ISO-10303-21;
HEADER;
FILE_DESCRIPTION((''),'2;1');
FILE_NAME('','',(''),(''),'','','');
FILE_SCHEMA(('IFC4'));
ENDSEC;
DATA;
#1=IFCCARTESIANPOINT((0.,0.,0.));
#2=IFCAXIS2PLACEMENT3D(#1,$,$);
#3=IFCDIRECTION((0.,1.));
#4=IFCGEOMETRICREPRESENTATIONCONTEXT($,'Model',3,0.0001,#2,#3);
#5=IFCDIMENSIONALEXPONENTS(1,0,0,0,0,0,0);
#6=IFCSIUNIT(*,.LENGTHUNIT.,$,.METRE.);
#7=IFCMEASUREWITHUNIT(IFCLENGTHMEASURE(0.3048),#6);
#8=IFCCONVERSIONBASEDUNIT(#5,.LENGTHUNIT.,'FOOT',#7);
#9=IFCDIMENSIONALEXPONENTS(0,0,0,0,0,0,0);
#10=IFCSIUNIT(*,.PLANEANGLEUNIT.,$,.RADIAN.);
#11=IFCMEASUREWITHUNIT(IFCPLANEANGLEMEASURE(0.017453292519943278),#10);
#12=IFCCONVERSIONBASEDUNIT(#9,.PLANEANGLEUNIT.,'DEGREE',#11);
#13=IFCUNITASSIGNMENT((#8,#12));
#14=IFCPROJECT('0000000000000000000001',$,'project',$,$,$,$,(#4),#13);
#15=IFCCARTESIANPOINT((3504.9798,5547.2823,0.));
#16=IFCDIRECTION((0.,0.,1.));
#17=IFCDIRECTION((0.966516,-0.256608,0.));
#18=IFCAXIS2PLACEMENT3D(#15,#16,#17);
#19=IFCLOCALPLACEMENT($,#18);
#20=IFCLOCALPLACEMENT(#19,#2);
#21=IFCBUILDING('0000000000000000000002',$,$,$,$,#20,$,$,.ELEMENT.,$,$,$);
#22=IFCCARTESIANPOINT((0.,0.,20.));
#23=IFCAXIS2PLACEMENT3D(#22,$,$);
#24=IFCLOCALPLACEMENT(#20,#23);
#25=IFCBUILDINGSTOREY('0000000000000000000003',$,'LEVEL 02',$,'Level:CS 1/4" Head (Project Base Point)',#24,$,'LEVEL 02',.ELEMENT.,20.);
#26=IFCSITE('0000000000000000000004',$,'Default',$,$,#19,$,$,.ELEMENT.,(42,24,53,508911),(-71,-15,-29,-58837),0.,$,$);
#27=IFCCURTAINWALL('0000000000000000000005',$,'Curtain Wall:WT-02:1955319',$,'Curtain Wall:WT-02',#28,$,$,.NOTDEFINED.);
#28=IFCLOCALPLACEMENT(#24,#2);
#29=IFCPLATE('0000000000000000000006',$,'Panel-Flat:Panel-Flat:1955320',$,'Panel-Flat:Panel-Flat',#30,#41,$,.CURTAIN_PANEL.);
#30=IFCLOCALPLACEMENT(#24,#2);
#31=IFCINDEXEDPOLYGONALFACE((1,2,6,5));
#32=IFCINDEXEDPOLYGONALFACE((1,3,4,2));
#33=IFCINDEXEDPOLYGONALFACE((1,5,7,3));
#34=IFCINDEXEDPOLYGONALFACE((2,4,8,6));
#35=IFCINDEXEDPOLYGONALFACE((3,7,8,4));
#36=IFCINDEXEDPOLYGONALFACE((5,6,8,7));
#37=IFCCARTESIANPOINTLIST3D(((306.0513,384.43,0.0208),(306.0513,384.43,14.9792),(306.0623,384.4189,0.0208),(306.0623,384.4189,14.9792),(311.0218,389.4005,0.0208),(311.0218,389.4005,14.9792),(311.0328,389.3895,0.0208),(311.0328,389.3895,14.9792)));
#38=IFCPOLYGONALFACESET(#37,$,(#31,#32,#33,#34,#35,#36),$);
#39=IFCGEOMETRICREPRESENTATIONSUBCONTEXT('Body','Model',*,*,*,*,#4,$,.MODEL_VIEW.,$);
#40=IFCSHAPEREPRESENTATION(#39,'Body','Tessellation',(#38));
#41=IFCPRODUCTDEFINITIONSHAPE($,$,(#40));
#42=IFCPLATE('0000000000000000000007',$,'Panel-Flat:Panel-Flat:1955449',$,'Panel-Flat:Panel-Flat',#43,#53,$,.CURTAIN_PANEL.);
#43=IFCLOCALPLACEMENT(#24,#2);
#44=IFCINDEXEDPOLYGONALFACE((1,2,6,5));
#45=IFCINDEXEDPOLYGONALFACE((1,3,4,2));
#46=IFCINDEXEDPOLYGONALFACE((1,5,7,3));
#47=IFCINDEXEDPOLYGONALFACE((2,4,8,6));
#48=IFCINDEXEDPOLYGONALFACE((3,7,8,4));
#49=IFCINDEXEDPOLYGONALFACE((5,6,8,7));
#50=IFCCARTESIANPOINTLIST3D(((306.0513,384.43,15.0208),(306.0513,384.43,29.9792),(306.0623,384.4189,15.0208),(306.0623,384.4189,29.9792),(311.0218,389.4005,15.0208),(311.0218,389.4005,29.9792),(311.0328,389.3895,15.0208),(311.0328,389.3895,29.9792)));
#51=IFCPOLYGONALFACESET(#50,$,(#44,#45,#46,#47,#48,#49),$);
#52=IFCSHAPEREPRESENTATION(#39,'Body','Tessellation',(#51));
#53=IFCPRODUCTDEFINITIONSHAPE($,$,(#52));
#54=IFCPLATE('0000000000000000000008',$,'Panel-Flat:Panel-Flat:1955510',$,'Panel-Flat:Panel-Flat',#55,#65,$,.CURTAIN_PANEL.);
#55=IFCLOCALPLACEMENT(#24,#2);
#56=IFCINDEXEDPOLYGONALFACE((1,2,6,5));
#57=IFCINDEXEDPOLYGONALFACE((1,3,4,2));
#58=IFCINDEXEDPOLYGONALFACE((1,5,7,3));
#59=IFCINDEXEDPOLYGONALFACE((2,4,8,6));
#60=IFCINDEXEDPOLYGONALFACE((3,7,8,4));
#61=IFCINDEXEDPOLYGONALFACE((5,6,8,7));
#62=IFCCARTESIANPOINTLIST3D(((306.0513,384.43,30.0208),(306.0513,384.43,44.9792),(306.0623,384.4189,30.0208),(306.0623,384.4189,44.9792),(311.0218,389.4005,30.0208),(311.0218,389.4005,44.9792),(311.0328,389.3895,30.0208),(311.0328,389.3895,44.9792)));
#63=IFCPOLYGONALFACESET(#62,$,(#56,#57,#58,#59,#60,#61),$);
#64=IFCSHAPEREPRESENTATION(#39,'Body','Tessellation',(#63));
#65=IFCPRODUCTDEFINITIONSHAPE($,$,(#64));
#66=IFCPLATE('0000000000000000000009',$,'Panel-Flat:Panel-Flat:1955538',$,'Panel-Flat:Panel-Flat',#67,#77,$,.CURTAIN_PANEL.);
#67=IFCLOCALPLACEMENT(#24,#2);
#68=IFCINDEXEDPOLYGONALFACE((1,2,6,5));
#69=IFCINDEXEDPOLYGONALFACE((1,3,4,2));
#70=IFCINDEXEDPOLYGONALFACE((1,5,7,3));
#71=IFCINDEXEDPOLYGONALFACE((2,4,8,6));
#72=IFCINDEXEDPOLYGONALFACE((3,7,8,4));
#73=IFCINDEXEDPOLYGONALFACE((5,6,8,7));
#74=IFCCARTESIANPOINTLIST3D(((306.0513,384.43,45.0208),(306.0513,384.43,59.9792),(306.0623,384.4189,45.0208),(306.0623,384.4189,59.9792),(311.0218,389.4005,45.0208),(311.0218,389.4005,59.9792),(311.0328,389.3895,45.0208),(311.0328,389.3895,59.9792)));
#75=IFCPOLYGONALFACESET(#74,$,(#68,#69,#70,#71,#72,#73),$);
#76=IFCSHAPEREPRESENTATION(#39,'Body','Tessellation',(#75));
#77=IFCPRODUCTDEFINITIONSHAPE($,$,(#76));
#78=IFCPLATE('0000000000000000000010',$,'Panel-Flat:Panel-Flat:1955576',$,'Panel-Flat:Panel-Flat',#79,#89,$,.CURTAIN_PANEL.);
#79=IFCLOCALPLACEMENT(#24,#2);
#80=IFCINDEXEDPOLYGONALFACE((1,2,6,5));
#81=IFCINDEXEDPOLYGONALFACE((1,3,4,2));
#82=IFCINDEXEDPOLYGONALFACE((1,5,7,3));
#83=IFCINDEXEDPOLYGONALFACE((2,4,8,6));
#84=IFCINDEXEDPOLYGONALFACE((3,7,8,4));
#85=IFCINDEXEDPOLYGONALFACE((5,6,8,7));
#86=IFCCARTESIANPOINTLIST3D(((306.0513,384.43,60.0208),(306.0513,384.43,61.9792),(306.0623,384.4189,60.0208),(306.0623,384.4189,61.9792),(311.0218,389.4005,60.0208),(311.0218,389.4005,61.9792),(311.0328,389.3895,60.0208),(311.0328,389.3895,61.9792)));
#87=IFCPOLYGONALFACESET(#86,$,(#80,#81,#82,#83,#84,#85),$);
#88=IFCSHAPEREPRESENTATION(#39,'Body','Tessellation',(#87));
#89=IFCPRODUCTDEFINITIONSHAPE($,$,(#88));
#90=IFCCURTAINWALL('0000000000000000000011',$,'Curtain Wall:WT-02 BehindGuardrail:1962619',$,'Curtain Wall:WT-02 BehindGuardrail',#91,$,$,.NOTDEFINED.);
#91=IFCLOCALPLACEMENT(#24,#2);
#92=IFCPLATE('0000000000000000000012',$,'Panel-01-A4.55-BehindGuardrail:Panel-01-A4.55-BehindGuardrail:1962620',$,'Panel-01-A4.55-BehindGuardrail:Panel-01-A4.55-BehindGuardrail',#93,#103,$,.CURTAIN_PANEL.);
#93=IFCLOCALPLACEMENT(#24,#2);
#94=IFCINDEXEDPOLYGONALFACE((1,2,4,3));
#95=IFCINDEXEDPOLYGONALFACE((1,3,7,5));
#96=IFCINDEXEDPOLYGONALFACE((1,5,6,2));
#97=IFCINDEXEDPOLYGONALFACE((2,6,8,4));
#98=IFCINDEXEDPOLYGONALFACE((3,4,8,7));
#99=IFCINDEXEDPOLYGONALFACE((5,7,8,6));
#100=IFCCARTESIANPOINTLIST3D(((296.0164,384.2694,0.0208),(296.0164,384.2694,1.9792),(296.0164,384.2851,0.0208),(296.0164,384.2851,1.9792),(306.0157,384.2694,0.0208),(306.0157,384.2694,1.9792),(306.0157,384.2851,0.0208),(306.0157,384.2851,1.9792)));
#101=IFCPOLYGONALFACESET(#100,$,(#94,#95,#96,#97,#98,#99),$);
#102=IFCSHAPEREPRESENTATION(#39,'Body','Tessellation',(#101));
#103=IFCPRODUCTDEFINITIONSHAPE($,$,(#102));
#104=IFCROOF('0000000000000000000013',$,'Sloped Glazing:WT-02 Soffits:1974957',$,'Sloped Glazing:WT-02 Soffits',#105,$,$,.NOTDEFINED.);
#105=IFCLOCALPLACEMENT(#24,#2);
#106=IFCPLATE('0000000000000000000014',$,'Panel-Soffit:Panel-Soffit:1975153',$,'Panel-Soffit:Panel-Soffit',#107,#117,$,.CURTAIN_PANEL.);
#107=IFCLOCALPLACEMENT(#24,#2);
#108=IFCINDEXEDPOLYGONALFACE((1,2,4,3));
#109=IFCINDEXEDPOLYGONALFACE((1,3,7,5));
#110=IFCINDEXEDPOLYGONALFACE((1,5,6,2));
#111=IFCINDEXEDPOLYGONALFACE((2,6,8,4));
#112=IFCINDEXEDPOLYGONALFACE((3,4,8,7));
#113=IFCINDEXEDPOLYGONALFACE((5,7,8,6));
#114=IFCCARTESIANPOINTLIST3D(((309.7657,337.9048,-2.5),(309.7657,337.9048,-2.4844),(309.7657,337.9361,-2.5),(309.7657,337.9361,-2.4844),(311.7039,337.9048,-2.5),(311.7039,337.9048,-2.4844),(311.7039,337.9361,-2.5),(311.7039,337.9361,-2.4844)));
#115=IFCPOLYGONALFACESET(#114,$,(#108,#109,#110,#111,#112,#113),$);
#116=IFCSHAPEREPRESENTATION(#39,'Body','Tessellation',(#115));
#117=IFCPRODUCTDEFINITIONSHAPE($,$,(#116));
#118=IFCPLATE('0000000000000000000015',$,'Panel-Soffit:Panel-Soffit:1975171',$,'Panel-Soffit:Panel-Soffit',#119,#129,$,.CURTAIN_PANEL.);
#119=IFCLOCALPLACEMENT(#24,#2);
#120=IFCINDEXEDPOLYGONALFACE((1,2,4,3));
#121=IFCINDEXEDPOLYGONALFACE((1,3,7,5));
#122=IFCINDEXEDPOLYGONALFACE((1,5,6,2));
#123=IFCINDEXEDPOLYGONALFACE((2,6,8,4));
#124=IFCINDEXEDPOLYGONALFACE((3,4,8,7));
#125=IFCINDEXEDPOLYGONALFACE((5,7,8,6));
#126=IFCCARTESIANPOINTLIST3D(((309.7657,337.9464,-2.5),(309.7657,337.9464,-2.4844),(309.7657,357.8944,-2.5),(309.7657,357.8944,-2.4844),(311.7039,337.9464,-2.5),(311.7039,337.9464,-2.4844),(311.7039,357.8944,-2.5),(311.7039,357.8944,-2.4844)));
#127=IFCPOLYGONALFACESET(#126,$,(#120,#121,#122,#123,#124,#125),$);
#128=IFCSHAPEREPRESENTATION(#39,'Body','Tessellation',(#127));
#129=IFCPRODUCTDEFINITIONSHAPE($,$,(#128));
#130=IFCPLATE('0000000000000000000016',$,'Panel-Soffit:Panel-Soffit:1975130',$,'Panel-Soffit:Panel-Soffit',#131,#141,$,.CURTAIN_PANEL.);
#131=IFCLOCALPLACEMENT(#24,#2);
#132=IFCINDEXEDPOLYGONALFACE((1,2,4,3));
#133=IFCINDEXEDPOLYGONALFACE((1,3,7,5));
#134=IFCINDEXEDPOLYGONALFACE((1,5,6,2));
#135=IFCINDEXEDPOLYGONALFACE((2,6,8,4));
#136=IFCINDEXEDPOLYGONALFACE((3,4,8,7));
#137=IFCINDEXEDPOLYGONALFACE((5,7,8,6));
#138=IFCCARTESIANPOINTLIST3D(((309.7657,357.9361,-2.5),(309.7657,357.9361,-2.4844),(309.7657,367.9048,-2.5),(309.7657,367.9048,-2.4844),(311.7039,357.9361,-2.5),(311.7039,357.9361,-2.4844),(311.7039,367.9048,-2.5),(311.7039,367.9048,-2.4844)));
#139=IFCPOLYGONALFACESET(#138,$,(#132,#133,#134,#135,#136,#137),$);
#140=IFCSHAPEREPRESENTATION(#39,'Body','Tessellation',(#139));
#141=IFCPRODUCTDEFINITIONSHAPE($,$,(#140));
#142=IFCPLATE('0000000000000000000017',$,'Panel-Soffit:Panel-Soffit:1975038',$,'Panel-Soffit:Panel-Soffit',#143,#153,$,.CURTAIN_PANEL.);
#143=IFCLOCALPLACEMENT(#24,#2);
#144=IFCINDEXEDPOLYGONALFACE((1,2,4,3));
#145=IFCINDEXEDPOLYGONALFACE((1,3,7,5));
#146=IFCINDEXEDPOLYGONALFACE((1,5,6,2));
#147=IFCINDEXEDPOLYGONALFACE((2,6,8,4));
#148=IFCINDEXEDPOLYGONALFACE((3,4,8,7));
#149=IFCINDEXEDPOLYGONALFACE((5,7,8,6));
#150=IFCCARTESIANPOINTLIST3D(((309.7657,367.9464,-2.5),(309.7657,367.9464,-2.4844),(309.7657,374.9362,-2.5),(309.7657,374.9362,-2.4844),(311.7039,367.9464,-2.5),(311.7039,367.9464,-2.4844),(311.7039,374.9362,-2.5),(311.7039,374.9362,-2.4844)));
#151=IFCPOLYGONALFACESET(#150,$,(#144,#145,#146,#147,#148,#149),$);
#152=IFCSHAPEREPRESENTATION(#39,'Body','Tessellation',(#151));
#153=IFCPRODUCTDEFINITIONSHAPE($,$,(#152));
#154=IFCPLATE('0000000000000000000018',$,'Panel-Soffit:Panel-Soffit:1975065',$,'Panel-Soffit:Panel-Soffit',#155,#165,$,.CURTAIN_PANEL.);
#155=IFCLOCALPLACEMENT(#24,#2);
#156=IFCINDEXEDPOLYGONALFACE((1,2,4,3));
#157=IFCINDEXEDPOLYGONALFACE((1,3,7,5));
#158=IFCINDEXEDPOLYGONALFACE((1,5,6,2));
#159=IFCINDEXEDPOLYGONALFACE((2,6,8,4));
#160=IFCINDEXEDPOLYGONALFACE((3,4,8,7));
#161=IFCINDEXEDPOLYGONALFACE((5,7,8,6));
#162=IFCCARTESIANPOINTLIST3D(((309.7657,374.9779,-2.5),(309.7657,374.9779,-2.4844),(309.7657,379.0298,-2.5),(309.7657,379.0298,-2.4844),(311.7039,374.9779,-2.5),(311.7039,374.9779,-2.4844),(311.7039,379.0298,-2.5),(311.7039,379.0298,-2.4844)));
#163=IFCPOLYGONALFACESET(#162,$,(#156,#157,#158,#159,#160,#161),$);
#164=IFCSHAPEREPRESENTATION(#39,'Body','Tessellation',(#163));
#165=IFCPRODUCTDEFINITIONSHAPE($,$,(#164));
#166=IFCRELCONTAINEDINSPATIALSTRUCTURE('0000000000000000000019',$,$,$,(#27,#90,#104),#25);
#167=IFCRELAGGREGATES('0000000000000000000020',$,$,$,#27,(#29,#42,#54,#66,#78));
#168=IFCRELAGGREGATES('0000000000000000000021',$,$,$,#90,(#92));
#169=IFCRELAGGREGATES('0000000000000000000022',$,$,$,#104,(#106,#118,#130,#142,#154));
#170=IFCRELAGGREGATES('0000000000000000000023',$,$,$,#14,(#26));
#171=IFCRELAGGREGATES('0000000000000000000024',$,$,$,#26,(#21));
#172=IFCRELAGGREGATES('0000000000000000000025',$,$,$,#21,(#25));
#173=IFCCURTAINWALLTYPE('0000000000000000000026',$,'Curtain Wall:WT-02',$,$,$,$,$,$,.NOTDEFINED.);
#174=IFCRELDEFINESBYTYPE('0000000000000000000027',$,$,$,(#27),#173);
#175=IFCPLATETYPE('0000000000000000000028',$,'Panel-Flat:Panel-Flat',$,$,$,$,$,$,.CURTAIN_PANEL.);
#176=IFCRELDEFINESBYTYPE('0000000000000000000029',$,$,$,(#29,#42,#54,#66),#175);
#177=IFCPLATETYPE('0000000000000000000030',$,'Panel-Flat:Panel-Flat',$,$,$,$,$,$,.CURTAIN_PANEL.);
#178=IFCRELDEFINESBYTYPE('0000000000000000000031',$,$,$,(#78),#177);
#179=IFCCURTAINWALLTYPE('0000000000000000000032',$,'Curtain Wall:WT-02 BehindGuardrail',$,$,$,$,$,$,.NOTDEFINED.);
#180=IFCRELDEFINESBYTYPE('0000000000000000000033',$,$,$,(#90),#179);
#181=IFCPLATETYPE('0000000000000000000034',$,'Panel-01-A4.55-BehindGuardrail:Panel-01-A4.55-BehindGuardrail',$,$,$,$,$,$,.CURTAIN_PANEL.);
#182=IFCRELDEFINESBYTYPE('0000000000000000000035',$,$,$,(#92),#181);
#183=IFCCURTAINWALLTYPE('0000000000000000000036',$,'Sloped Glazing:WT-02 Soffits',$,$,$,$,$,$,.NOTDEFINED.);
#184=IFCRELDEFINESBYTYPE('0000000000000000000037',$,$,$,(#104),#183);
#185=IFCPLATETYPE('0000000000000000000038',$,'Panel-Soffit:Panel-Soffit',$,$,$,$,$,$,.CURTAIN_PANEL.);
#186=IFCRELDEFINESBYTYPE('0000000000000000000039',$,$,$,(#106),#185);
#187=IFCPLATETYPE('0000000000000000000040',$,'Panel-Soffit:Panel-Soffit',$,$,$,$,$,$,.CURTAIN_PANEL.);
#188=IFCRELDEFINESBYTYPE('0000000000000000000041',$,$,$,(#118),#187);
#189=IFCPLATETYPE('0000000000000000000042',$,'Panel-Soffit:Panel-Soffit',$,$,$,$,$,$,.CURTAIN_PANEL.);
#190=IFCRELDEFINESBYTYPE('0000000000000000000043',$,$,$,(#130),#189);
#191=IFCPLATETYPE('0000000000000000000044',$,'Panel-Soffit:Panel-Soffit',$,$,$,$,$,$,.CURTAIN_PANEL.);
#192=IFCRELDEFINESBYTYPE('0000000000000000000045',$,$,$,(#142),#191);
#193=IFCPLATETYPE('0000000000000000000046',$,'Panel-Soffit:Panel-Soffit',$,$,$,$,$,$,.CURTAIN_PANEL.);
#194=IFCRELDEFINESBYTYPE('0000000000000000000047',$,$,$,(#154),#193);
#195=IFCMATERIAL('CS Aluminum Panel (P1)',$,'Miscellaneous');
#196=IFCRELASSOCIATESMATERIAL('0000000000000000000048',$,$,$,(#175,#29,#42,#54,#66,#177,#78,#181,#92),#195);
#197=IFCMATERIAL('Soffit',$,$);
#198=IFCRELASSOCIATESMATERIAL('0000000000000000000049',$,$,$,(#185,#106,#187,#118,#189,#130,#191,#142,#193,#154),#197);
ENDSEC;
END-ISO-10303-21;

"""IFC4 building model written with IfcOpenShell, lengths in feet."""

from ifc_helpers import new_model, entity, si_unit, converted_unit, direction, frame, origin, place, context, subcontext, project, spatial, indexed_curve, outline, extrude, source, transform, mapped, material, type_object, type_shapes, element, aggregate, save


model = new_model("IFC4")

# Units and contexts
model_context = context("Model", 3, precision=0.0001, world=origin(), true_north=direction((0.0, 1.0)))
body_context = subcontext(model_context, "Body", "Model", "MODEL_VIEW")
ifc_project = project(units=[converted_unit("LENGTHUNIT", "FOOT", entity("IfcLengthMeasure", 0.3048), si_unit("LENGTHUNIT", "METRE"), dimensions=[1, 0, 0, 0, 0, 0, 0]), converted_unit("PLANEANGLEUNIT", "DEGREE", entity("IfcPlaneAngleMeasure", 0.017453292519943278), si_unit("PLANEANGLEUNIT", "RADIAN"), dimensions=[0, 0, 0, 0, 0, 0, 0])], contexts=[model_context])

# Site, building, storey
site_placement = place(None, frame((3504.9798, 5547.2823, 0.0), z_axis=(0.0, 0.0, 1.0), x_axis=(0.966516, -0.256608, 0.0)))
site = spatial("IfcSite", under=ifc_project, at=site_placement, Name="Default", CompositionType="ELEMENT", RefLatitude=(42, 24, 53, 508911), RefLongitude=(-71, -15, -29, -58837), RefElevation=0.0)
building_placement = place(site_placement, origin())
building = spatial("IfcBuilding", under=site, at=building_placement, CompositionType="ELEMENT")
storey_placement = place(building_placement, frame((0.0, 0.0, 20.0)))
storey = spatial("IfcBuildingStorey", under=building, at=storey_placement, Name="LEVEL 02", ObjectType="Level:CS 1/4\" Head (Project Base Point)", LongName="LEVEL 02", CompositionType="ELEMENT", Elevation=20.0)

# Shared definitions
curtain_wall_type_1 = type_object("IfcCurtainWallType", Name="Curtain Wall:WT-02", PredefinedType="NOTDEFINED")
ifc_material_1 = material(Name="CS Aluminum Panel (P1)", Category="Miscellaneous")

# Shared definitions
curtain_wall_type_2 = type_object("IfcCurtainWallType", Name="Sloped Glazing:WT-02 Soffits", PredefinedType="NOTDEFINED")
ifc_material_2 = material(Name="Soffit")

# Curtain wall, plates
curtain_wall_1_placement = place(storey_placement, frame((0.0, 0.0, -20.0)))
curtain_wall_1 = element("IfcCurtainWall", 1, at=curtain_wall_1_placement, inside=storey, type_object=curtain_wall_type_1, Name="Curtain Wall:WT-02:1955319", ObjectType="Curtain Wall:WT-02", PredefinedType="NOTDEFINED")
plate_type_1 = type_object("IfcPlateType", Name="Panel-Flat:Panel-Flat", PredefinedType="CURTAIN_PANEL", material=ifc_material_1)
shared_shape_1 = source(origin(), body_context, "Body", "SweptSolid", [
    extrude(outline(indexed_curve([(-0.0078, -3.5147), (0.0078, -3.5147), (0.0078, 3.5147), (-0.0078, 3.5147), (-0.0078, -3.5147)], self_intersect=False)), frame((0.0, -0.0078, 0.0208), z_axis=(0.0, 0.0, 1.0), x_axis=(0.0, -1.0, 0.0)), (0.0, 0.0, 1.0), 14.9583),
])
type_shapes(plate_type_1, [shared_shape_1])
plate_1_placement = place(curtain_wall_1_placement, frame((308.5365, 386.9153, 20.0), z_axis=(0.0, 0.0, 1.0), x_axis=(0.707107, 0.707107, 0.0)))
plate_1 = element("IfcPlate", 2, at=plate_1_placement, type_object=plate_type_1, material=ifc_material_1, Name="Panel-Flat:Panel-Flat:1955320", ObjectType="Panel-Flat:Panel-Flat", PredefinedType="CURTAIN_PANEL", context=body_context, shape_type="MappedRepresentation", body=[
    mapped(shared_shape_1, transform((0.0, 0.0, 0.0), scale=1.0)),
])
plate_2_placement = place(curtain_wall_1_placement, frame((308.5365, 386.9153, 35.0), z_axis=(0.0, 0.0, 1.0), x_axis=(0.707107, 0.707107, 0.0)))
plate_2 = element("IfcPlate", 3, at=plate_2_placement, type_object=plate_type_1, material=ifc_material_1, Name="Panel-Flat:Panel-Flat:1955449", ObjectType="Panel-Flat:Panel-Flat", PredefinedType="CURTAIN_PANEL", context=body_context, shape_type="MappedRepresentation", body=[
    mapped(shared_shape_1, transform((0.0, 0.0, 0.0), scale=1.0)),
])
plate_3_placement = place(curtain_wall_1_placement, frame((308.5365, 386.9153, 50.0), z_axis=(0.0, 0.0, 1.0), x_axis=(0.707107, 0.707107, 0.0)))
plate_3 = element("IfcPlate", 4, at=plate_3_placement, type_object=plate_type_1, material=ifc_material_1, Name="Panel-Flat:Panel-Flat:1955510", ObjectType="Panel-Flat:Panel-Flat", PredefinedType="CURTAIN_PANEL", context=body_context, shape_type="MappedRepresentation", body=[
    mapped(shared_shape_1, transform((0.0, 0.0, 0.0), scale=1.0)),
])
plate_4_placement = place(curtain_wall_1_placement, frame((308.5365, 386.9153, 65.0), z_axis=(0.0, 0.0, 1.0), x_axis=(0.707107, 0.707107, 0.0)))
plate_4 = element("IfcPlate", 5, at=plate_4_placement, type_object=plate_type_1, material=ifc_material_1, Name="Panel-Flat:Panel-Flat:1955538", ObjectType="Panel-Flat:Panel-Flat", PredefinedType="CURTAIN_PANEL", context=body_context, shape_type="MappedRepresentation", body=[
    mapped(shared_shape_1, transform((0.0, 0.0, 0.0), scale=1.0)),
])
plate_type_2 = type_object("IfcPlateType", Name="Panel-Flat:Panel-Flat", PredefinedType="CURTAIN_PANEL", material=ifc_material_1)
shared_shape_2 = source(origin(), body_context, "Body", "SweptSolid", [
    extrude(outline(indexed_curve([(-0.0078, -3.5147), (0.0078, -3.5147), (0.0078, 3.5147), (-0.0078, 3.5147), (-0.0078, -3.5147)], self_intersect=False)), frame((0.0, -0.0078, 0.0208), z_axis=(0.0, 0.0, 1.0), x_axis=(0.0, -1.0, 0.0)), (0.0, 0.0, 1.0), 1.9583),
])
type_shapes(plate_type_2, [shared_shape_2])
plate_5_placement = place(curtain_wall_1_placement, frame((308.5365, 386.9153, 80.0), z_axis=(0.0, 0.0, 1.0), x_axis=(0.707107, 0.707107, 0.0)))
plate_5 = element("IfcPlate", 6, at=plate_5_placement, type_object=plate_type_2, material=ifc_material_1, Name="Panel-Flat:Panel-Flat:1955576", ObjectType="Panel-Flat:Panel-Flat", PredefinedType="CURTAIN_PANEL", context=body_context, shape_type="MappedRepresentation", body=[
    mapped(shared_shape_2, transform((0.0, 0.0, 0.0), scale=1.0)),
])
aggregate(curtain_wall_1, [plate_1, plate_2, plate_3, plate_4, plate_5])

# Curtain wall, plate
curtain_wall_type_3 = type_object("IfcCurtainWallType", Name="Curtain Wall:WT-02 BehindGuardrail", PredefinedType="NOTDEFINED")
curtain_wall_2_placement = place(storey_placement, frame((0.0, 0.0, -20.0)))
curtain_wall_2 = element("IfcCurtainWall", 7, at=curtain_wall_2_placement, inside=storey, type_object=curtain_wall_type_3, Name="Curtain Wall:WT-02 BehindGuardrail:1962619", ObjectType="Curtain Wall:WT-02 BehindGuardrail", PredefinedType="NOTDEFINED")
plate_type_3 = type_object("IfcPlateType", Name="Panel-01-A4.55-BehindGuardrail:Panel-01-A4.55-BehindGuardrail", PredefinedType="CURTAIN_PANEL", material=ifc_material_1)
shared_shape_3 = source(origin(), body_context, "Body", "SweptSolid", [
    extrude(outline(indexed_curve([(-0.0078, -4.9996), (0.0078, -4.9996), (0.0078, 4.9996), (-0.0078, 4.9996), (-0.0078, -4.9996)], self_intersect=False)), frame((0.0, -0.0078, 0.0208), z_axis=(0.0, 0.0, 1.0), x_axis=(0.0, -1.0, 0.0)), (0.0, 0.0, 1.0), 1.9583),
])
type_shapes(plate_type_3, [shared_shape_3])
plate_6_placement = place(curtain_wall_2_placement, frame((301.0161, 384.2694, 20.0), z_axis=(0.0, 0.0, 1.0), x_axis=(-1.0, 0.0, 0.0)))
plate_6 = element("IfcPlate", 8, at=plate_6_placement, type_object=plate_type_3, material=ifc_material_1, Name="Panel-01-A4.55-BehindGuardrail:Panel-01-A4.55-BehindGuardrail:1962620", ObjectType="Panel-01-A4.55-BehindGuardrail:Panel-01-A4.55-BehindGuardrail", PredefinedType="CURTAIN_PANEL", context=body_context, shape_type="MappedRepresentation", body=[
    mapped(shared_shape_3, transform((0.0, 0.0, 0.0), scale=1.0)),
])
aggregate(curtain_wall_2, [plate_6])

# Roof, plates
roof_1_placement = place(storey_placement, frame((0.0, 0.0, -20.0)))
roof_1 = element("IfcRoof", 9, at=roof_1_placement, inside=storey, type_object=curtain_wall_type_2, Name="Sloped Glazing:WT-02 Soffits:1974957", ObjectType="Sloped Glazing:WT-02 Soffits", PredefinedType="NOTDEFINED")
plate_type_4 = type_object("IfcPlateType", Name="Panel-Soffit:Panel-Soffit", PredefinedType="CURTAIN_PANEL", material=ifc_material_2)
shared_shape_4 = source(origin(), body_context, "Body", "SweptSolid", [
    extrude(outline(indexed_curve([(-0.0078, -0.9691), (0.0078, -0.9691), (0.0078, 0.9691), (-0.0078, 0.9691), (-0.0078, -0.9691)], self_intersect=False)), frame((0.0, -0.0078, -0.0105), z_axis=(0.0, 0.0, 1.0), x_axis=(0.0, -1.0, 0.0)), (0.0, 0.0, 1.0), 0.0313),
])
type_shapes(plate_type_4, [shared_shape_4])
plate_7_placement = place(roof_1_placement, frame((310.7348, 337.9153, 17.5), z_axis=(0.0, 1.0, 0.0), x_axis=(1.0, 0.0, 0.0)))
plate_7 = element("IfcPlate", 10, at=plate_7_placement, type_object=plate_type_4, material=ifc_material_2, Name="Panel-Soffit:Panel-Soffit:1975153", ObjectType="Panel-Soffit:Panel-Soffit", PredefinedType="CURTAIN_PANEL", context=body_context, shape_type="MappedRepresentation", body=[
    mapped(shared_shape_4, transform((0.0, 0.0, 0.0), scale=1.0)),
])
plate_type_5 = type_object("IfcPlateType", Name="Panel-Soffit:Panel-Soffit", PredefinedType="CURTAIN_PANEL", material=ifc_material_2)
shared_shape_5 = source(origin(), body_context, "Body", "SweptSolid", [
    extrude(outline(indexed_curve([(-0.0078, -0.9691), (0.0078, -0.9691), (0.0078, 0.9691), (-0.0078, 0.9691), (-0.0078, -0.9691)], self_intersect=False)), frame((0.0, -0.0078, 0.0208), z_axis=(0.0, 0.0, 1.0), x_axis=(0.0, -1.0, 0.0)), (0.0, 0.0, 1.0), 19.948),
])
type_shapes(plate_type_5, [shared_shape_5])
plate_8_placement = place(roof_1_placement, frame((310.7348, 337.9256, 17.5), z_axis=(0.0, 1.0, 0.0), x_axis=(1.0, 0.0, 0.0)))
plate_8 = element("IfcPlate", 11, at=plate_8_placement, type_object=plate_type_5, material=ifc_material_2, Name="Panel-Soffit:Panel-Soffit:1975171", ObjectType="Panel-Soffit:Panel-Soffit", PredefinedType="CURTAIN_PANEL", context=body_context, shape_type="MappedRepresentation", body=[
    mapped(shared_shape_5, transform((0.0, 0.0, 0.0), scale=1.0)),
])
plate_type_6 = type_object("IfcPlateType", Name="Panel-Soffit:Panel-Soffit", PredefinedType="CURTAIN_PANEL", material=ifc_material_2)
shared_shape_6 = source(origin(), body_context, "Body", "SweptSolid", [
    extrude(outline(indexed_curve([(-0.0078, -0.9691), (0.0078, -0.9691), (0.0078, 0.9691), (-0.0078, 0.9691), (-0.0078, -0.9691)], self_intersect=False)), frame((0.0, -0.0078, 0.0208), z_axis=(0.0, 0.0, 1.0), x_axis=(0.0, -1.0, 0.0)), (0.0, 0.0, 1.0), 9.9687),
])
type_shapes(plate_type_6, [shared_shape_6])
plate_9_placement = place(roof_1_placement, frame((310.7348, 357.9153, 17.5), z_axis=(0.0, 1.0, 0.0), x_axis=(1.0, 0.0, 0.0)))
plate_9 = element("IfcPlate", 12, at=plate_9_placement, type_object=plate_type_6, material=ifc_material_2, Name="Panel-Soffit:Panel-Soffit:1975130", ObjectType="Panel-Soffit:Panel-Soffit", PredefinedType="CURTAIN_PANEL", context=body_context, shape_type="MappedRepresentation", body=[
    mapped(shared_shape_6, transform((0.0, 0.0, 0.0), scale=1.0)),
])
plate_type_7 = type_object("IfcPlateType", Name="Panel-Soffit:Panel-Soffit", PredefinedType="CURTAIN_PANEL", material=ifc_material_2)
shared_shape_7 = source(origin(), body_context, "Body", "SweptSolid", [
    extrude(outline(indexed_curve([(-0.0078, -0.9691), (0.0078, -0.9691), (0.0078, 0.9691), (-0.0078, 0.9691), (-0.0078, -0.9691)], self_intersect=False)), frame((0.0, -0.0078, 0.0208), z_axis=(0.0, 0.0, 1.0), x_axis=(0.0, -1.0, 0.0)), (0.0, 0.0, 1.0), 6.9898),
])
type_shapes(plate_type_7, [shared_shape_7])
plate_10_placement = place(roof_1_placement, frame((310.7348, 367.9256, 17.5), z_axis=(0.0, 1.0, 0.0), x_axis=(1.0, 0.0, 0.0)))
plate_10 = element("IfcPlate", 13, at=plate_10_placement, type_object=plate_type_7, material=ifc_material_2, Name="Panel-Soffit:Panel-Soffit:1975038", ObjectType="Panel-Soffit:Panel-Soffit", PredefinedType="CURTAIN_PANEL", context=body_context, shape_type="MappedRepresentation", body=[
    mapped(shared_shape_7, transform((0.0, 0.0, 0.0), scale=1.0)),
])
plate_type_8 = type_object("IfcPlateType", Name="Panel-Soffit:Panel-Soffit", PredefinedType="CURTAIN_PANEL", material=ifc_material_2)
shared_shape_8 = source(origin(), body_context, "Body", "SweptSolid", [
    extrude(outline(indexed_curve([(-0.0078, -0.9691), (0.0078, -0.9691), (0.0078, 0.9691), (-0.0078, 0.9691), (-0.0078, -0.9691)], self_intersect=False)), frame((0.0, -0.0078, 0.0208), z_axis=(0.0, 0.0, 1.0), x_axis=(0.0, -1.0, 0.0)), (0.0, 0.0, 1.0), 4.052),
])
type_shapes(plate_type_8, [shared_shape_8])
plate_11_placement = place(roof_1_placement, frame((310.7348, 374.957, 17.5), z_axis=(0.0, 1.0, 0.0), x_axis=(1.0, 0.0, 0.0)))
plate_11 = element("IfcPlate", 14, at=plate_11_placement, type_object=plate_type_8, material=ifc_material_2, Name="Panel-Soffit:Panel-Soffit:1975065", ObjectType="Panel-Soffit:Panel-Soffit", PredefinedType="CURTAIN_PANEL", context=body_context, shape_type="MappedRepresentation", body=[
    mapped(shared_shape_8, transform((0.0, 0.0, 0.0), scale=1.0)),
])
aggregate(roof_1, [plate_7, plate_8, plate_9, plate_10, plate_11])

save(model, "model.ifc")
